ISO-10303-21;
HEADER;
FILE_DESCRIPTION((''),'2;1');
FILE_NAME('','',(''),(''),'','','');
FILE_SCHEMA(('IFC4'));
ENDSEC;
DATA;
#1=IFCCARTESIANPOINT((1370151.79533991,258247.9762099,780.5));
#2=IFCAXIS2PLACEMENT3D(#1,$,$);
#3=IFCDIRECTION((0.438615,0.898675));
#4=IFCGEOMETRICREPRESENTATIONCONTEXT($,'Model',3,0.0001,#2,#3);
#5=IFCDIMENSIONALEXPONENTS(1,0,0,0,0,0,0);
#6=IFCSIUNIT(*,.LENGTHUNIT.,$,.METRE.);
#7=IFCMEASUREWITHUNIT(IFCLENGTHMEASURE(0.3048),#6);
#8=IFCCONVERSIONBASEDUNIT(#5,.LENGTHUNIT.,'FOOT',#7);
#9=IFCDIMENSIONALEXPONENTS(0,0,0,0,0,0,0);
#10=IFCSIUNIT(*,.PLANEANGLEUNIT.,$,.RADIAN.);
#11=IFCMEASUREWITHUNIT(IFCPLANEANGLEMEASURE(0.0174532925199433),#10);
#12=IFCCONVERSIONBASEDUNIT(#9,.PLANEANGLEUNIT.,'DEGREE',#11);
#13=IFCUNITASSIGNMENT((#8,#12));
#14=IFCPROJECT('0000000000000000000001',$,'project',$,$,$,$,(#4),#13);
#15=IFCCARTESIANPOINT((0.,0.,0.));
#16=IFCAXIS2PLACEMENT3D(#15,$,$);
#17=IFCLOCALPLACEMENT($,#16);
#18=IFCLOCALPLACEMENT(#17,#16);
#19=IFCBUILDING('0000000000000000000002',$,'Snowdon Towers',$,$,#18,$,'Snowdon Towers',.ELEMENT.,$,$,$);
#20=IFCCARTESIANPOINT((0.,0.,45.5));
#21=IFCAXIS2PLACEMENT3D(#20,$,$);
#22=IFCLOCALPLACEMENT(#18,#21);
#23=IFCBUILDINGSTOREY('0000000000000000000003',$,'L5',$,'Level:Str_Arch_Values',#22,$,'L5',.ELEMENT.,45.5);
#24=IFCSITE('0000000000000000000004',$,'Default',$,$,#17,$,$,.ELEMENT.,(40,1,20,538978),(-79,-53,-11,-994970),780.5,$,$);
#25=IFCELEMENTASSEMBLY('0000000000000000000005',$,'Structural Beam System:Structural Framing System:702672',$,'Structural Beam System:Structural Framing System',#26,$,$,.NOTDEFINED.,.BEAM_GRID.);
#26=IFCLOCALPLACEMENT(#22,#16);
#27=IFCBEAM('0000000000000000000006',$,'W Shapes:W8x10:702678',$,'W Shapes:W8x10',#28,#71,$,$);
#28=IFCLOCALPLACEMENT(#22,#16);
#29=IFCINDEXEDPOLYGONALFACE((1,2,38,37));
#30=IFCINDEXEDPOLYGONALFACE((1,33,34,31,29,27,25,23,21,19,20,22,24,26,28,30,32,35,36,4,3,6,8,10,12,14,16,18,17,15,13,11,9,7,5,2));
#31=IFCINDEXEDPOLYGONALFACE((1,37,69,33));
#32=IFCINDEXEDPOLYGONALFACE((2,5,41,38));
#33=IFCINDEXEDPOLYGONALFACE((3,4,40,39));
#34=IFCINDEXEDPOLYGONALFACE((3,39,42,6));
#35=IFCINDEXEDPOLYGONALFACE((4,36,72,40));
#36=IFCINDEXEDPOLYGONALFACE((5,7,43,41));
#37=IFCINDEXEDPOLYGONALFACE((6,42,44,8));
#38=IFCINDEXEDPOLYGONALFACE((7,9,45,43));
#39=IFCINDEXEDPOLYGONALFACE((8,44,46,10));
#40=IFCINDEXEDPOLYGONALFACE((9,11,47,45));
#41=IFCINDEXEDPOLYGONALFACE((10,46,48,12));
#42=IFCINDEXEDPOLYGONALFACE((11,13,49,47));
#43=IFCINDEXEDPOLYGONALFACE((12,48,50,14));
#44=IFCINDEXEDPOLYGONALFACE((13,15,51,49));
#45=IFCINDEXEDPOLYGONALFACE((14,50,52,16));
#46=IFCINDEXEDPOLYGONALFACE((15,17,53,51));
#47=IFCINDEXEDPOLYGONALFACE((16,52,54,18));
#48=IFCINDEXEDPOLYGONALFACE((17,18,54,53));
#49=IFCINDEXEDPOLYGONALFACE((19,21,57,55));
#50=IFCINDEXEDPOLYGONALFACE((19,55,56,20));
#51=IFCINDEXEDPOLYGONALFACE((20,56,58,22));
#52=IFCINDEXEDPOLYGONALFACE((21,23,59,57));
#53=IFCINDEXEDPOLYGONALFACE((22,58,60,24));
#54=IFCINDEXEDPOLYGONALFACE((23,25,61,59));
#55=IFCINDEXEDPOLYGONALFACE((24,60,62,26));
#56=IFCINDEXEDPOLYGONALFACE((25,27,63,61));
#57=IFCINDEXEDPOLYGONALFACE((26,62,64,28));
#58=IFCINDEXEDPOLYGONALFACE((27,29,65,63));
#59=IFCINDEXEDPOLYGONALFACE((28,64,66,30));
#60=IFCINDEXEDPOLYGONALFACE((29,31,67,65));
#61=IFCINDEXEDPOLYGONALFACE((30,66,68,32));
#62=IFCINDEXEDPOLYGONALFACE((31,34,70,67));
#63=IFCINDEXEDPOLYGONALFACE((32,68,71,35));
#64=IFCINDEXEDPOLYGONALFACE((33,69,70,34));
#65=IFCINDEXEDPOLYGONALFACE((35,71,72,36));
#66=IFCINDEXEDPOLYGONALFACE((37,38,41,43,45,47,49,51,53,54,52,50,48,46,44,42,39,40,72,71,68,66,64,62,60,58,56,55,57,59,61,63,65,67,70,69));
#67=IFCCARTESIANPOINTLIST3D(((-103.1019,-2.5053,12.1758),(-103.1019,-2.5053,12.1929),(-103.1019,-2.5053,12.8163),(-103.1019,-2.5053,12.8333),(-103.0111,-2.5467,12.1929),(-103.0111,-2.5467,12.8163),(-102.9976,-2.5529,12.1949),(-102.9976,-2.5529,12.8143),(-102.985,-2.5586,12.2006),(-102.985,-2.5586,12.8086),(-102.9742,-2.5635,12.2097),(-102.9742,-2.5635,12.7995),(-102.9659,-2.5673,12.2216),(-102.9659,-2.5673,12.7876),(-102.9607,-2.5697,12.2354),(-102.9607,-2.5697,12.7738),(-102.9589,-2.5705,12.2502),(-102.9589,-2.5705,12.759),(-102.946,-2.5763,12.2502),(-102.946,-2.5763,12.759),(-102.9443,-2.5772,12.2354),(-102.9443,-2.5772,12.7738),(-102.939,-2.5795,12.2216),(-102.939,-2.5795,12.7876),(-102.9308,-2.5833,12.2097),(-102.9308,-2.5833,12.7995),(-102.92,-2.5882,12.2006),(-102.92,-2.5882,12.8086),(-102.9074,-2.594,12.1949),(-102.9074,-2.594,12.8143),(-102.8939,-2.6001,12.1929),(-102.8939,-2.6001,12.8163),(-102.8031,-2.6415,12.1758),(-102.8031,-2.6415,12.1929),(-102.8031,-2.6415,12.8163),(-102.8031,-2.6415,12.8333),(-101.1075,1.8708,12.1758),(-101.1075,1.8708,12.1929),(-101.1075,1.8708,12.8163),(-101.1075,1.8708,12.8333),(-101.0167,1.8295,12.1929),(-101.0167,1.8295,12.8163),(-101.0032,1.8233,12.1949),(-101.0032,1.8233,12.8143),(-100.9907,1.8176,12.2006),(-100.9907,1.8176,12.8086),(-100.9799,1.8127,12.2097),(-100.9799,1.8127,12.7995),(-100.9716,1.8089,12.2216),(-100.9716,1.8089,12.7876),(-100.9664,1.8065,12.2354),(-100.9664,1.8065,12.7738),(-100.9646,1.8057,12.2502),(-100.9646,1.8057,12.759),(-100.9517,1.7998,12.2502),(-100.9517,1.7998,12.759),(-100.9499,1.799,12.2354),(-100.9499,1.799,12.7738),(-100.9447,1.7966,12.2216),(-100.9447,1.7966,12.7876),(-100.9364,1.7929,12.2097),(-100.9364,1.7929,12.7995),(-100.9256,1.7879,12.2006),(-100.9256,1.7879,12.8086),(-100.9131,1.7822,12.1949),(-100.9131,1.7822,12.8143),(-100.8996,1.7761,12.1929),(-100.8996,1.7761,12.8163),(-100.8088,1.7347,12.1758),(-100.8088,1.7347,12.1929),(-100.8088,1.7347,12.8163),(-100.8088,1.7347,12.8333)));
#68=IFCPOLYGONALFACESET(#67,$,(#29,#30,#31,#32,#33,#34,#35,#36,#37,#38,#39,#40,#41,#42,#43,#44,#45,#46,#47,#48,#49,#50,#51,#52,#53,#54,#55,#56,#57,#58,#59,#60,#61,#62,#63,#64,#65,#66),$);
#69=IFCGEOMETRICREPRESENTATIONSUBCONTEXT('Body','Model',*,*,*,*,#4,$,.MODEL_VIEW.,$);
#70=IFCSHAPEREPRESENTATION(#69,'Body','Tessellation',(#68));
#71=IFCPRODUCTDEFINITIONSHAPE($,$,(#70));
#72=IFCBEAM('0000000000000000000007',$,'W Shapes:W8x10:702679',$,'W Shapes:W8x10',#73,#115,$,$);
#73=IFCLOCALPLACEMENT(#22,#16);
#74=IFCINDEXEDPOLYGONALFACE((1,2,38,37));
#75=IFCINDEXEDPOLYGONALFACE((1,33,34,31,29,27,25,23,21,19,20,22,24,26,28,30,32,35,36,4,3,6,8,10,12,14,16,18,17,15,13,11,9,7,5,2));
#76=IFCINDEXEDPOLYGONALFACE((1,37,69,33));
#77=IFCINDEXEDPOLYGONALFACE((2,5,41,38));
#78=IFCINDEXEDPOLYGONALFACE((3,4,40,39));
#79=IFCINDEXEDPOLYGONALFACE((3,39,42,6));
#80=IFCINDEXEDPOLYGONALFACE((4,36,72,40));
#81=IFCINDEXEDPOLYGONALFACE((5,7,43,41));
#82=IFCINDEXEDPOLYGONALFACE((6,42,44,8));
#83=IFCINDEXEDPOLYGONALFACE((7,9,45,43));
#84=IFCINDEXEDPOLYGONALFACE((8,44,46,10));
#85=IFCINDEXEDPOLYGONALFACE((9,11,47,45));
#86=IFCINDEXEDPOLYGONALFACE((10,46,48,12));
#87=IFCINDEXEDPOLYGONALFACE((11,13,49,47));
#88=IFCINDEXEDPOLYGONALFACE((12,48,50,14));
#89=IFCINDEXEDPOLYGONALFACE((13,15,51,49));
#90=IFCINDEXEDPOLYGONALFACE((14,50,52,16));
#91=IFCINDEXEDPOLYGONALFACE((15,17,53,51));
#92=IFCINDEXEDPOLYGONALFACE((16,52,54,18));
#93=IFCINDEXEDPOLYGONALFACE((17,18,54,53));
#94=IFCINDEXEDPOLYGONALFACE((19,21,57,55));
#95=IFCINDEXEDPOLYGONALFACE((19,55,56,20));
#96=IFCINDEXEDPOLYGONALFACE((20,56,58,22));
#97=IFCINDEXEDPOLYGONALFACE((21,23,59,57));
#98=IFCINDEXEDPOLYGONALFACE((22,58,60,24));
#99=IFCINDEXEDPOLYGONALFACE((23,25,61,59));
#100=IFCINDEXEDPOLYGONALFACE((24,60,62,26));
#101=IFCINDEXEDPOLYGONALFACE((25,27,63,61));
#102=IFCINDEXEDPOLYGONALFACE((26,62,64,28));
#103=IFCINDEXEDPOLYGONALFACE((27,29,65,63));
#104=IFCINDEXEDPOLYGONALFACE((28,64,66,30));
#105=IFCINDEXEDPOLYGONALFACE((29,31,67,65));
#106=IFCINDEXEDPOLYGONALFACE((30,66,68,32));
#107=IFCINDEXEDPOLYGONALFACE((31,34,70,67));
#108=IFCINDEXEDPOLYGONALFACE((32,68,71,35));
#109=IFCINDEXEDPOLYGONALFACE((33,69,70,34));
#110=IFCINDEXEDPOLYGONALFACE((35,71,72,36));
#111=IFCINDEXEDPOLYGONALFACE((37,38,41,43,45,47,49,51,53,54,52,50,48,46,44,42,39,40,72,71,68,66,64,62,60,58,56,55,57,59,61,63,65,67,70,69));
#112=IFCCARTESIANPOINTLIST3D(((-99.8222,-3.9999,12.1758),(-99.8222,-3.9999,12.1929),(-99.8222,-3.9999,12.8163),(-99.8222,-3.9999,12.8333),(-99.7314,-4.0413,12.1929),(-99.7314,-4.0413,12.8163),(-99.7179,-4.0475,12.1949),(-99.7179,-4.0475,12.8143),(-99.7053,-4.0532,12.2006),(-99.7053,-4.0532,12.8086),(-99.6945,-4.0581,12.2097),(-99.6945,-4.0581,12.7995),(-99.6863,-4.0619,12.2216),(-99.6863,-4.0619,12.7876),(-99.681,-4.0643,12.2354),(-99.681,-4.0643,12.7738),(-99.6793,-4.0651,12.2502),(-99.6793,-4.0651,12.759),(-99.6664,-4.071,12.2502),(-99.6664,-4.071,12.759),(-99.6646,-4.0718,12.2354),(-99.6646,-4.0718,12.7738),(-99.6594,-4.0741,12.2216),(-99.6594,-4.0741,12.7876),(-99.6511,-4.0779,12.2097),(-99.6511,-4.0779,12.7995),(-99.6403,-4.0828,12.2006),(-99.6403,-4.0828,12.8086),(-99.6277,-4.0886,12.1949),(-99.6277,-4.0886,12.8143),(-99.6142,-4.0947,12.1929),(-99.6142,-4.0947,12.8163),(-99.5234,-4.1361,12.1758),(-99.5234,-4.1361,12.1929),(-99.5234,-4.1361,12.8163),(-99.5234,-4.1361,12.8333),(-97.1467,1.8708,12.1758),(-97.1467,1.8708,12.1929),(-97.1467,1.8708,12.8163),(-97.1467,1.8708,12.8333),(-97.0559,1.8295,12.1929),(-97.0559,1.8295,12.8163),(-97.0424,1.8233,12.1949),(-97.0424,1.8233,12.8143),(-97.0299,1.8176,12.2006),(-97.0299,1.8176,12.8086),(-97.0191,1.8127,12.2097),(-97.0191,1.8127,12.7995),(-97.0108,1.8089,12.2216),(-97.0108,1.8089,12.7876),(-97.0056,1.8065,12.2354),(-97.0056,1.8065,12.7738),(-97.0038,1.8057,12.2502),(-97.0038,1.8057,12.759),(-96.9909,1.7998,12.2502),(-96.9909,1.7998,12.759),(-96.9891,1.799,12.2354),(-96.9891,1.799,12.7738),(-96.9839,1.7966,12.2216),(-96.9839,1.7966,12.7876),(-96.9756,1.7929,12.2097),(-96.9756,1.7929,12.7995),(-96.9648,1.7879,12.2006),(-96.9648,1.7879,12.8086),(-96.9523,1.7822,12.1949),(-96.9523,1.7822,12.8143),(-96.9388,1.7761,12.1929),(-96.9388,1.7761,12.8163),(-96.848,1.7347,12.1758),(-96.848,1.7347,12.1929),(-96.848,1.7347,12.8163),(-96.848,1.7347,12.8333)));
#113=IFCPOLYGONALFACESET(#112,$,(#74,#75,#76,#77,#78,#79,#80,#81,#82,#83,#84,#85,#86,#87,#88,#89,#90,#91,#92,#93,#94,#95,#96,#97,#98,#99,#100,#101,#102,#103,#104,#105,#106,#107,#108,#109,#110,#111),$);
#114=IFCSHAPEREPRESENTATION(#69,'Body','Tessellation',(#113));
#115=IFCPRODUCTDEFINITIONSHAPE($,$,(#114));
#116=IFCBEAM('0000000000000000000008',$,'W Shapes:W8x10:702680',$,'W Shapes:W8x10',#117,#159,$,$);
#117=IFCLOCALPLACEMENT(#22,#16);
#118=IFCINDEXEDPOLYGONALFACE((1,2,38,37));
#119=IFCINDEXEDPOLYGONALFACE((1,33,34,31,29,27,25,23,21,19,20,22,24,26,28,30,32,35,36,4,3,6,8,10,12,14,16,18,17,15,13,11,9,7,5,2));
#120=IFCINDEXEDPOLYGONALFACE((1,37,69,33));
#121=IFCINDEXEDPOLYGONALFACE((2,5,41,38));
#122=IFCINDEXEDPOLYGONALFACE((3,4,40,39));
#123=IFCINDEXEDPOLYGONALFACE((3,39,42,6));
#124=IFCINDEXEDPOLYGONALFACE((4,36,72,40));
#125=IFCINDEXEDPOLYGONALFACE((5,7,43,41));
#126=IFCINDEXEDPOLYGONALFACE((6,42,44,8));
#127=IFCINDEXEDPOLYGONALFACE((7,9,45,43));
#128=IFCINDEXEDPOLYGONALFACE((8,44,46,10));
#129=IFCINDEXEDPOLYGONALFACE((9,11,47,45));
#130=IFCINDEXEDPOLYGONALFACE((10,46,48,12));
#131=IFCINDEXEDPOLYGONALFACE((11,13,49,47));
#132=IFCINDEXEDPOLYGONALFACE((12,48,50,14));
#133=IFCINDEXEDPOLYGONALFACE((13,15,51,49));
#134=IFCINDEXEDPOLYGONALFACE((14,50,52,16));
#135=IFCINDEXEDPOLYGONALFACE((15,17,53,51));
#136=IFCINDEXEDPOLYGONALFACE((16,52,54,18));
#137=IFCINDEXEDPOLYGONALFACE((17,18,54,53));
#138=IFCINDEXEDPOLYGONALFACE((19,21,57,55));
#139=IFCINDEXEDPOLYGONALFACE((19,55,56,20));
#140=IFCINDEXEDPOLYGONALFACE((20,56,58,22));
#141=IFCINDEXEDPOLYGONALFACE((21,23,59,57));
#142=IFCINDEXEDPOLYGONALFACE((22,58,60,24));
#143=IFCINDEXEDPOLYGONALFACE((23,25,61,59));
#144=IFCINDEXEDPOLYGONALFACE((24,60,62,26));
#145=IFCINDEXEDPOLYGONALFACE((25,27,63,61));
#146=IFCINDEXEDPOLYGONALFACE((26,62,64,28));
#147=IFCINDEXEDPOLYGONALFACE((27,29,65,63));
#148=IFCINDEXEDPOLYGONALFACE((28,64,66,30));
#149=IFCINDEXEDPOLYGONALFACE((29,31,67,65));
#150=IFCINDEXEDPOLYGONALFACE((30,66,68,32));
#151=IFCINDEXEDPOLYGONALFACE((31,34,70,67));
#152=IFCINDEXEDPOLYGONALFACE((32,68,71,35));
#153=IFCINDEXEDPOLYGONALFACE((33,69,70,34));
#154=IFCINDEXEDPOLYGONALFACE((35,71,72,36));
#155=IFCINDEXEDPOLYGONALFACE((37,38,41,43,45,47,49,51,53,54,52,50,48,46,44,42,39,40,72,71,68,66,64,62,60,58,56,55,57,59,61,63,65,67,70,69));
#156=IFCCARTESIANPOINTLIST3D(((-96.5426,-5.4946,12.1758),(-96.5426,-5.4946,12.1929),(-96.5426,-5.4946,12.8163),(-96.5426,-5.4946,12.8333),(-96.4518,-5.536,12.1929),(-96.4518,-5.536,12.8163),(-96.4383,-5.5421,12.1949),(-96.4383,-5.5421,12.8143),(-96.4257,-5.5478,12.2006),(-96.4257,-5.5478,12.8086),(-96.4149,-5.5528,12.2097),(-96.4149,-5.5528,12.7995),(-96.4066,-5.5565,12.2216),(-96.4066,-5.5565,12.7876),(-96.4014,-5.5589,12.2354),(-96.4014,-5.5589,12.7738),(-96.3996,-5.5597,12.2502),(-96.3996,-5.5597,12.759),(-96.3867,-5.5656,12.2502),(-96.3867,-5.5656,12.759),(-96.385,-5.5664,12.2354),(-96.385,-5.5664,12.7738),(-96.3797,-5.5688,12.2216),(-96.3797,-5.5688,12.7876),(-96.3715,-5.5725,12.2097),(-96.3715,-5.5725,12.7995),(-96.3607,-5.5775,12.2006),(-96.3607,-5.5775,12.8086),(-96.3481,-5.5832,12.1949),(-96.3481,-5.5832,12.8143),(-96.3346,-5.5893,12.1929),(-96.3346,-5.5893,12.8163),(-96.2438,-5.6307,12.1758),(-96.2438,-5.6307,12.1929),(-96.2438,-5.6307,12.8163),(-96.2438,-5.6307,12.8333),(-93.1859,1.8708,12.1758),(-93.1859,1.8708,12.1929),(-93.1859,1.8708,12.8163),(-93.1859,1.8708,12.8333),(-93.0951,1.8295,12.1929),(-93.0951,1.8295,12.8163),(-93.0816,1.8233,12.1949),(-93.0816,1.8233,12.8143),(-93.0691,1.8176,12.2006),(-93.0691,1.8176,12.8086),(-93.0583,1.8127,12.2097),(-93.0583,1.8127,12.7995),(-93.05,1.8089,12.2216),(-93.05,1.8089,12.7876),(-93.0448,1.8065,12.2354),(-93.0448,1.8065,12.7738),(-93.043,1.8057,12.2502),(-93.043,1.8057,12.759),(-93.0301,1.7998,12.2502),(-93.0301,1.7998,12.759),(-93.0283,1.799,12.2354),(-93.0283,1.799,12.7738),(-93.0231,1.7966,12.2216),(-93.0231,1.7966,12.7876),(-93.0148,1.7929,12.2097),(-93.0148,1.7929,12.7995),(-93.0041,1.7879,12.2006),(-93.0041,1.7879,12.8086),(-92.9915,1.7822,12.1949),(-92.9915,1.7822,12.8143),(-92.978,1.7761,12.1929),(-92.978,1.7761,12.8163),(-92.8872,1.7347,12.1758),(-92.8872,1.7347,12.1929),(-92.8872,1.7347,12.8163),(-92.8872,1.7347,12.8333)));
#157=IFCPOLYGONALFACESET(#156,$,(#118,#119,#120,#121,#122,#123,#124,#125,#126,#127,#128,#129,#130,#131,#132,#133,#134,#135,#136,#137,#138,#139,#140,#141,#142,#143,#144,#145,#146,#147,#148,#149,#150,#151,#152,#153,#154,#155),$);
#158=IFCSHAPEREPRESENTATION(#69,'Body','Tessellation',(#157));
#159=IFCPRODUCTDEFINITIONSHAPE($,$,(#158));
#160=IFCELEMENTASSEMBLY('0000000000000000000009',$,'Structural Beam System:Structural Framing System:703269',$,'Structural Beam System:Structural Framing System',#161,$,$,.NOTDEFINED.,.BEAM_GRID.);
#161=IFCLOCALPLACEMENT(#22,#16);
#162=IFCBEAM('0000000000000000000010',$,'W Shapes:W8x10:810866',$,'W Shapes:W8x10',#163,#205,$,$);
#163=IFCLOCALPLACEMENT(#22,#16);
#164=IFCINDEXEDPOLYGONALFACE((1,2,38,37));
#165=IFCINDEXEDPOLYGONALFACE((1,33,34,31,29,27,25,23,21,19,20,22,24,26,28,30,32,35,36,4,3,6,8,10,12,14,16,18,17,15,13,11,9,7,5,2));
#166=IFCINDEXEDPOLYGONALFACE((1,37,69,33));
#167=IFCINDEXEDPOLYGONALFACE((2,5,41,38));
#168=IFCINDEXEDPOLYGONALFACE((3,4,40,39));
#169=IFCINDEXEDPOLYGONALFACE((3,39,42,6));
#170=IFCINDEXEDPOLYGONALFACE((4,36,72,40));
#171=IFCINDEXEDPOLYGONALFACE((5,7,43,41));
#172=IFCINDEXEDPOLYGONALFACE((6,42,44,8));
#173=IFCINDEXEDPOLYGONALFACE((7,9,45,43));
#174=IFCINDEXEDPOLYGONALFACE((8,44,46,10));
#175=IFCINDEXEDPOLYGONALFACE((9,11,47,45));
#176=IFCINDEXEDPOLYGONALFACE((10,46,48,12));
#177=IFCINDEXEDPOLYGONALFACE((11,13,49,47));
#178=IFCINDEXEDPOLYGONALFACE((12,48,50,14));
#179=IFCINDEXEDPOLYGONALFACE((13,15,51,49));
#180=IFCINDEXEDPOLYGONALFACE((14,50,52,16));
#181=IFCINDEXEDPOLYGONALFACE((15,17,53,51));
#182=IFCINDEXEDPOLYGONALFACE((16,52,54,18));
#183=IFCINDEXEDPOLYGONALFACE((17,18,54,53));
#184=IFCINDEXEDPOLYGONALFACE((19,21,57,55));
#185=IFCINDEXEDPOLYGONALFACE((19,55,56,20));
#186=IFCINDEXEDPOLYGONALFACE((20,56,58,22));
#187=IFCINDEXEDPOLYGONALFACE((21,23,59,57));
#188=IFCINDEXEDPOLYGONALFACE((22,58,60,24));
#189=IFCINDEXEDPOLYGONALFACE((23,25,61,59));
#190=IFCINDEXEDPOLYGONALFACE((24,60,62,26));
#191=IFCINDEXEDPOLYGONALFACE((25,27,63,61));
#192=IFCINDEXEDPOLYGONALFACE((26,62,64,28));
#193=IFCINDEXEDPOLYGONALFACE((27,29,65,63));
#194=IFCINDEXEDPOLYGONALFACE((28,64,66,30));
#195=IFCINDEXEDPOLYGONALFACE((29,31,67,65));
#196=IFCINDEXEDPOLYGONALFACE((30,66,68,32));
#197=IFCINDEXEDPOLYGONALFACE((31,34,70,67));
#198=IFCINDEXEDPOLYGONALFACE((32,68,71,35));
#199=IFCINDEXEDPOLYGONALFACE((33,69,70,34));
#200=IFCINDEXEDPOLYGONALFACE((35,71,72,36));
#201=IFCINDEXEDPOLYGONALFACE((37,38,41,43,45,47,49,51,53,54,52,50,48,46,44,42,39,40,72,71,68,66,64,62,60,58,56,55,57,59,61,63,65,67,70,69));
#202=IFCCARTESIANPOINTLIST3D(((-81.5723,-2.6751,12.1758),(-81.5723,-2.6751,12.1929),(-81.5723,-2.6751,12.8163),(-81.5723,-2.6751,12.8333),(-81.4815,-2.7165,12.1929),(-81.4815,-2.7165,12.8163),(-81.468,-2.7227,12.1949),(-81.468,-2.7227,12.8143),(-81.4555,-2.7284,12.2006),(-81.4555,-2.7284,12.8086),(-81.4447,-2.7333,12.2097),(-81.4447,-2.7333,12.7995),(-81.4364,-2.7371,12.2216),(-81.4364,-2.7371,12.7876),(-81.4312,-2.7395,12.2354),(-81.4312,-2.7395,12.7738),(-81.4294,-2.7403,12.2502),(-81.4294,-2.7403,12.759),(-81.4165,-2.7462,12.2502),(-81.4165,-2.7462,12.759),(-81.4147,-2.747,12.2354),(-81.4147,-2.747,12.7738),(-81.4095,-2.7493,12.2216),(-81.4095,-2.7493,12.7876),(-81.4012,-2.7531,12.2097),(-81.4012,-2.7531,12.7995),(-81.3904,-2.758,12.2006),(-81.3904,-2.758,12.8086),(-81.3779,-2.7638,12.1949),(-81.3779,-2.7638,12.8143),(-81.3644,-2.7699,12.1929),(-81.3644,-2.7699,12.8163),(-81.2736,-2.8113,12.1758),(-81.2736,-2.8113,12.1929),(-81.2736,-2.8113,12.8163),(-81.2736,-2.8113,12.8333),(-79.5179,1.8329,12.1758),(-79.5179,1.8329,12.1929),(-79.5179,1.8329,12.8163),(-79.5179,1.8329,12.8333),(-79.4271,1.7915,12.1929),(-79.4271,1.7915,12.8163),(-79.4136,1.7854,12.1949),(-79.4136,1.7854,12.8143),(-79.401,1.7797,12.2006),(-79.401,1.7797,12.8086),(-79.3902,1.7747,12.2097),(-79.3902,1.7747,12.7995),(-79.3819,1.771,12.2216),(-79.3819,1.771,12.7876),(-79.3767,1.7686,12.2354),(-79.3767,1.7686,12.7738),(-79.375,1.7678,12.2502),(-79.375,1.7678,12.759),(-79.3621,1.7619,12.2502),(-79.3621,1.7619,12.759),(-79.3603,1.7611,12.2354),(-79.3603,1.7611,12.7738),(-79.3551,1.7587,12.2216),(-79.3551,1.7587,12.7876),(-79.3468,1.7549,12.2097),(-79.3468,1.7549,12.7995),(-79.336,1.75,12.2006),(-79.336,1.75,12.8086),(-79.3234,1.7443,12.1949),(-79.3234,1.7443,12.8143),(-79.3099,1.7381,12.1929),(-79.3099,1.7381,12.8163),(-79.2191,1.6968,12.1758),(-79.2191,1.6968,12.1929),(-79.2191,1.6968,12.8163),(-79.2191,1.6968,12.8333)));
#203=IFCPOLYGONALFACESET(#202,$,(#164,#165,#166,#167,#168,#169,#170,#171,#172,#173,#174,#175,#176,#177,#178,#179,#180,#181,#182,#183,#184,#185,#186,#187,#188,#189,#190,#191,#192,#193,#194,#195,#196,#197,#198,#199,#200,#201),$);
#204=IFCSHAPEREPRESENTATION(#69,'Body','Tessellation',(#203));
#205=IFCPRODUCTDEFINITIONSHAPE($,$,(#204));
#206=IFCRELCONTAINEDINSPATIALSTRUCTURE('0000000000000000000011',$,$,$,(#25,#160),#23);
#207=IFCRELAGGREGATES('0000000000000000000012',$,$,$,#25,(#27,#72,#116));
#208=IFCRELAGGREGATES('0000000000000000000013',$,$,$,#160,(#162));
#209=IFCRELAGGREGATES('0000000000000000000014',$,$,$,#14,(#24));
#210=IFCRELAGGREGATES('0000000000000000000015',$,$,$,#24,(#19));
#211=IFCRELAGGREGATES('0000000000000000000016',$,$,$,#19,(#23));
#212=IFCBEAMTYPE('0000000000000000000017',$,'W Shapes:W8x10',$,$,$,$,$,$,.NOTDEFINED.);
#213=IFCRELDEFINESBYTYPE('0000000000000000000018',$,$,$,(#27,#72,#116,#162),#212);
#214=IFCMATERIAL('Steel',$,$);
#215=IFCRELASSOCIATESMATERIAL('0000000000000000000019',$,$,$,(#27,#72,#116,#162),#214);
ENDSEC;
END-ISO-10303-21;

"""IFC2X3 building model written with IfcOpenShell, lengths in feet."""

from ifc_helpers import new_model, entity, si_unit, converted_unit, direction, frame, frame_2d, origin, place, context, subcontext, project, spatial, i_section, extrude, material, type_object, element, aggregate, save


model = new_model("IFC2X3")

# Units and contexts
model_context = context("Model", 3, precision=0.0001, world=frame((1370151.79533991, 258247.9762099, 780.5)), true_north=direction((0.438615, 0.898675)))
body_context = subcontext(model_context, "Body", "Model", "MODEL_VIEW")
ifc_project = project(units=[converted_unit("LENGTHUNIT", "FOOT", entity("IfcLengthMeasure", 0.3048), si_unit("LENGTHUNIT", "METRE"), dimensions=[1, 0, 0, 0, 0, 0, 0]), converted_unit("PLANEANGLEUNIT", "DEGREE", entity("IfcPlaneAngleMeasure", 0.0174532925199433), si_unit("PLANEANGLEUNIT", "RADIAN"), dimensions=[0, 0, 0, 0, 0, 0, 0])], contexts=[model_context])

# Site, building, storey
site_placement = place(None, origin())
site = spatial("IfcSite", under=ifc_project, at=site_placement, Name="Default", CompositionType="ELEMENT", RefLatitude=(40, 1, 20, 538978), RefLongitude=(-79, -53, -11, -994970), RefElevation=780.5)
building_placement = place(site_placement, origin())
building = spatial("IfcBuilding", under=site, at=building_placement, Name="Snowdon Towers", LongName="Snowdon Towers", CompositionType="ELEMENT")
storey_placement = place(building_placement, frame((0.0, 0.0, 45.5)))
storey = spatial("IfcBuildingStorey", under=building, at=storey_placement, Name="L5", ObjectType="Level:Str_Arch_Values", LongName="L5", CompositionType="ELEMENT", Elevation=45.5)

# Shared definitions
ifc_material = material(Name="Steel")

# Element assemblies, beams
assembly_1_placement = place(storey_placement, origin())
assembly_1 = element("IfcElementAssembly", 1, at=assembly_1_placement, inside=storey, Name="Structural Beam System:Structural Framing System:702672", ObjectType="Structural Beam System:Structural Framing System", AssemblyPlace="NOTDEFINED", PredefinedType="BEAM_GRID")
beam_type_1 = type_object("IfcBeamType", Name="W Shapes:W8x10", PredefinedType="NOTDEFINED")
beam_1_placement = place(assembly_1_placement, frame((-103.0646, -2.8195, 12.8333), z_axis=(0.0, 0.0, 1.0), x_axis=(0.414693, 0.909961, 0.0)))
beam_1 = element("IfcBeam", 2, at=beam_1_placement, type_object=beam_type_1, material=ifc_material, Name="W Shapes:W8x10:702678", ObjectType="W Shapes:W8x10", context=body_context, shape_type="SweptSolid", body=[
    extrude(i_section(OverallWidth=0.3283, OverallDepth=0.6575, WebThickness=0.0142, FlangeThickness=0.0171, FilletRadius=0.0573, at=frame_2d((0.0, 0.0), x_axis=(0.0, 1.0))), frame((0.2704, 0.0, -0.3288), z_axis=(1.0, 0.0, 0.0), x_axis=(0.0, 0.0, -1.0)), (0.0, 0.0, 1.0), 4.8092),
])
beam_2_placement = place(assembly_1_placement, frame((-99.785, -4.3141, 12.8333), z_axis=(0.0, 0.0, 1.0), x_axis=(0.414693, 0.909961, 0.0)))
beam_2 = element("IfcBeam", 3, at=beam_2_placement, type_object=beam_type_1, material=ifc_material, Name="W Shapes:W8x10:702679", ObjectType="W Shapes:W8x10", context=body_context, shape_type="SweptSolid", body=[
    extrude(i_section(OverallWidth=0.3283, OverallDepth=0.6575, WebThickness=0.0142, FlangeThickness=0.0171, FilletRadius=0.0573, at=frame_2d((0.0, 0.0), x_axis=(0.0, 1.0))), frame((0.2704, 0.0, -0.3288), z_axis=(1.0, 0.0, 0.0), x_axis=(0.0, 0.0, -1.0)), (0.0, 0.0, 1.0), 6.4517),
])
beam_3_placement = place(assembly_1_placement, frame((-96.5053, -5.8087, 12.8333), z_axis=(0.0, 0.0, 1.0), x_axis=(0.414693, 0.909961, 0.0)))
beam_3 = element("IfcBeam", 4, at=beam_3_placement, type_object=beam_type_1, material=ifc_material, Name="W Shapes:W8x10:702680", ObjectType="W Shapes:W8x10", context=body_context, shape_type="SweptSolid", body=[
    extrude(i_section(OverallWidth=0.3283, OverallDepth=0.6575, WebThickness=0.0142, FlangeThickness=0.0171, FilletRadius=0.0573, at=frame_2d((0.0, 0.0), x_axis=(0.0, 1.0))), frame((0.2704, 0.0, -0.3288), z_axis=(1.0, 0.0, 0.0), x_axis=(0.0, 0.0, -1.0)), (0.0, 0.0, 1.0), 8.0942),
])
aggregate(assembly_1, [beam_1, beam_2, beam_3])
assembly_2_placement = place(storey_placement, origin())
assembly_2 = element("IfcElementAssembly", 5, at=assembly_2_placement, inside=storey, Name="Structural Beam System:Structural Framing System:703269", ObjectType="Structural Beam System:Structural Framing System", AssemblyPlace="NOTDEFINED", PredefinedType="BEAM_GRID")
beam_4_placement = place(assembly_2_placement, frame((-81.5524, -3.0272, 12.8333), z_axis=(0.0, 0.0, 1.0), x_axis=(0.414693, 0.909961, 0.0)))
beam_4 = element("IfcBeam", 6, at=beam_4_placement, type_object=beam_type_1, material=ifc_material, Name="W Shapes:W8x10:810866", ObjectType="W Shapes:W8x10", context=body_context, shape_type="SweptSolid", body=[
    extrude(i_section(OverallWidth=0.3283, OverallDepth=0.6575, WebThickness=0.0142, FlangeThickness=0.0171, FilletRadius=0.0573, at=frame_2d((0.0, 0.0), x_axis=(0.0, 1.0))), frame((0.3121, 0.0, -0.3288), z_axis=(1.0, 0.0, 0.0), x_axis=(0.0, 0.0, -1.0)), (0.0, 0.0, 1.0), 4.9541),
])
aggregate(assembly_2, [beam_4])

save(model, "model.ifc")
